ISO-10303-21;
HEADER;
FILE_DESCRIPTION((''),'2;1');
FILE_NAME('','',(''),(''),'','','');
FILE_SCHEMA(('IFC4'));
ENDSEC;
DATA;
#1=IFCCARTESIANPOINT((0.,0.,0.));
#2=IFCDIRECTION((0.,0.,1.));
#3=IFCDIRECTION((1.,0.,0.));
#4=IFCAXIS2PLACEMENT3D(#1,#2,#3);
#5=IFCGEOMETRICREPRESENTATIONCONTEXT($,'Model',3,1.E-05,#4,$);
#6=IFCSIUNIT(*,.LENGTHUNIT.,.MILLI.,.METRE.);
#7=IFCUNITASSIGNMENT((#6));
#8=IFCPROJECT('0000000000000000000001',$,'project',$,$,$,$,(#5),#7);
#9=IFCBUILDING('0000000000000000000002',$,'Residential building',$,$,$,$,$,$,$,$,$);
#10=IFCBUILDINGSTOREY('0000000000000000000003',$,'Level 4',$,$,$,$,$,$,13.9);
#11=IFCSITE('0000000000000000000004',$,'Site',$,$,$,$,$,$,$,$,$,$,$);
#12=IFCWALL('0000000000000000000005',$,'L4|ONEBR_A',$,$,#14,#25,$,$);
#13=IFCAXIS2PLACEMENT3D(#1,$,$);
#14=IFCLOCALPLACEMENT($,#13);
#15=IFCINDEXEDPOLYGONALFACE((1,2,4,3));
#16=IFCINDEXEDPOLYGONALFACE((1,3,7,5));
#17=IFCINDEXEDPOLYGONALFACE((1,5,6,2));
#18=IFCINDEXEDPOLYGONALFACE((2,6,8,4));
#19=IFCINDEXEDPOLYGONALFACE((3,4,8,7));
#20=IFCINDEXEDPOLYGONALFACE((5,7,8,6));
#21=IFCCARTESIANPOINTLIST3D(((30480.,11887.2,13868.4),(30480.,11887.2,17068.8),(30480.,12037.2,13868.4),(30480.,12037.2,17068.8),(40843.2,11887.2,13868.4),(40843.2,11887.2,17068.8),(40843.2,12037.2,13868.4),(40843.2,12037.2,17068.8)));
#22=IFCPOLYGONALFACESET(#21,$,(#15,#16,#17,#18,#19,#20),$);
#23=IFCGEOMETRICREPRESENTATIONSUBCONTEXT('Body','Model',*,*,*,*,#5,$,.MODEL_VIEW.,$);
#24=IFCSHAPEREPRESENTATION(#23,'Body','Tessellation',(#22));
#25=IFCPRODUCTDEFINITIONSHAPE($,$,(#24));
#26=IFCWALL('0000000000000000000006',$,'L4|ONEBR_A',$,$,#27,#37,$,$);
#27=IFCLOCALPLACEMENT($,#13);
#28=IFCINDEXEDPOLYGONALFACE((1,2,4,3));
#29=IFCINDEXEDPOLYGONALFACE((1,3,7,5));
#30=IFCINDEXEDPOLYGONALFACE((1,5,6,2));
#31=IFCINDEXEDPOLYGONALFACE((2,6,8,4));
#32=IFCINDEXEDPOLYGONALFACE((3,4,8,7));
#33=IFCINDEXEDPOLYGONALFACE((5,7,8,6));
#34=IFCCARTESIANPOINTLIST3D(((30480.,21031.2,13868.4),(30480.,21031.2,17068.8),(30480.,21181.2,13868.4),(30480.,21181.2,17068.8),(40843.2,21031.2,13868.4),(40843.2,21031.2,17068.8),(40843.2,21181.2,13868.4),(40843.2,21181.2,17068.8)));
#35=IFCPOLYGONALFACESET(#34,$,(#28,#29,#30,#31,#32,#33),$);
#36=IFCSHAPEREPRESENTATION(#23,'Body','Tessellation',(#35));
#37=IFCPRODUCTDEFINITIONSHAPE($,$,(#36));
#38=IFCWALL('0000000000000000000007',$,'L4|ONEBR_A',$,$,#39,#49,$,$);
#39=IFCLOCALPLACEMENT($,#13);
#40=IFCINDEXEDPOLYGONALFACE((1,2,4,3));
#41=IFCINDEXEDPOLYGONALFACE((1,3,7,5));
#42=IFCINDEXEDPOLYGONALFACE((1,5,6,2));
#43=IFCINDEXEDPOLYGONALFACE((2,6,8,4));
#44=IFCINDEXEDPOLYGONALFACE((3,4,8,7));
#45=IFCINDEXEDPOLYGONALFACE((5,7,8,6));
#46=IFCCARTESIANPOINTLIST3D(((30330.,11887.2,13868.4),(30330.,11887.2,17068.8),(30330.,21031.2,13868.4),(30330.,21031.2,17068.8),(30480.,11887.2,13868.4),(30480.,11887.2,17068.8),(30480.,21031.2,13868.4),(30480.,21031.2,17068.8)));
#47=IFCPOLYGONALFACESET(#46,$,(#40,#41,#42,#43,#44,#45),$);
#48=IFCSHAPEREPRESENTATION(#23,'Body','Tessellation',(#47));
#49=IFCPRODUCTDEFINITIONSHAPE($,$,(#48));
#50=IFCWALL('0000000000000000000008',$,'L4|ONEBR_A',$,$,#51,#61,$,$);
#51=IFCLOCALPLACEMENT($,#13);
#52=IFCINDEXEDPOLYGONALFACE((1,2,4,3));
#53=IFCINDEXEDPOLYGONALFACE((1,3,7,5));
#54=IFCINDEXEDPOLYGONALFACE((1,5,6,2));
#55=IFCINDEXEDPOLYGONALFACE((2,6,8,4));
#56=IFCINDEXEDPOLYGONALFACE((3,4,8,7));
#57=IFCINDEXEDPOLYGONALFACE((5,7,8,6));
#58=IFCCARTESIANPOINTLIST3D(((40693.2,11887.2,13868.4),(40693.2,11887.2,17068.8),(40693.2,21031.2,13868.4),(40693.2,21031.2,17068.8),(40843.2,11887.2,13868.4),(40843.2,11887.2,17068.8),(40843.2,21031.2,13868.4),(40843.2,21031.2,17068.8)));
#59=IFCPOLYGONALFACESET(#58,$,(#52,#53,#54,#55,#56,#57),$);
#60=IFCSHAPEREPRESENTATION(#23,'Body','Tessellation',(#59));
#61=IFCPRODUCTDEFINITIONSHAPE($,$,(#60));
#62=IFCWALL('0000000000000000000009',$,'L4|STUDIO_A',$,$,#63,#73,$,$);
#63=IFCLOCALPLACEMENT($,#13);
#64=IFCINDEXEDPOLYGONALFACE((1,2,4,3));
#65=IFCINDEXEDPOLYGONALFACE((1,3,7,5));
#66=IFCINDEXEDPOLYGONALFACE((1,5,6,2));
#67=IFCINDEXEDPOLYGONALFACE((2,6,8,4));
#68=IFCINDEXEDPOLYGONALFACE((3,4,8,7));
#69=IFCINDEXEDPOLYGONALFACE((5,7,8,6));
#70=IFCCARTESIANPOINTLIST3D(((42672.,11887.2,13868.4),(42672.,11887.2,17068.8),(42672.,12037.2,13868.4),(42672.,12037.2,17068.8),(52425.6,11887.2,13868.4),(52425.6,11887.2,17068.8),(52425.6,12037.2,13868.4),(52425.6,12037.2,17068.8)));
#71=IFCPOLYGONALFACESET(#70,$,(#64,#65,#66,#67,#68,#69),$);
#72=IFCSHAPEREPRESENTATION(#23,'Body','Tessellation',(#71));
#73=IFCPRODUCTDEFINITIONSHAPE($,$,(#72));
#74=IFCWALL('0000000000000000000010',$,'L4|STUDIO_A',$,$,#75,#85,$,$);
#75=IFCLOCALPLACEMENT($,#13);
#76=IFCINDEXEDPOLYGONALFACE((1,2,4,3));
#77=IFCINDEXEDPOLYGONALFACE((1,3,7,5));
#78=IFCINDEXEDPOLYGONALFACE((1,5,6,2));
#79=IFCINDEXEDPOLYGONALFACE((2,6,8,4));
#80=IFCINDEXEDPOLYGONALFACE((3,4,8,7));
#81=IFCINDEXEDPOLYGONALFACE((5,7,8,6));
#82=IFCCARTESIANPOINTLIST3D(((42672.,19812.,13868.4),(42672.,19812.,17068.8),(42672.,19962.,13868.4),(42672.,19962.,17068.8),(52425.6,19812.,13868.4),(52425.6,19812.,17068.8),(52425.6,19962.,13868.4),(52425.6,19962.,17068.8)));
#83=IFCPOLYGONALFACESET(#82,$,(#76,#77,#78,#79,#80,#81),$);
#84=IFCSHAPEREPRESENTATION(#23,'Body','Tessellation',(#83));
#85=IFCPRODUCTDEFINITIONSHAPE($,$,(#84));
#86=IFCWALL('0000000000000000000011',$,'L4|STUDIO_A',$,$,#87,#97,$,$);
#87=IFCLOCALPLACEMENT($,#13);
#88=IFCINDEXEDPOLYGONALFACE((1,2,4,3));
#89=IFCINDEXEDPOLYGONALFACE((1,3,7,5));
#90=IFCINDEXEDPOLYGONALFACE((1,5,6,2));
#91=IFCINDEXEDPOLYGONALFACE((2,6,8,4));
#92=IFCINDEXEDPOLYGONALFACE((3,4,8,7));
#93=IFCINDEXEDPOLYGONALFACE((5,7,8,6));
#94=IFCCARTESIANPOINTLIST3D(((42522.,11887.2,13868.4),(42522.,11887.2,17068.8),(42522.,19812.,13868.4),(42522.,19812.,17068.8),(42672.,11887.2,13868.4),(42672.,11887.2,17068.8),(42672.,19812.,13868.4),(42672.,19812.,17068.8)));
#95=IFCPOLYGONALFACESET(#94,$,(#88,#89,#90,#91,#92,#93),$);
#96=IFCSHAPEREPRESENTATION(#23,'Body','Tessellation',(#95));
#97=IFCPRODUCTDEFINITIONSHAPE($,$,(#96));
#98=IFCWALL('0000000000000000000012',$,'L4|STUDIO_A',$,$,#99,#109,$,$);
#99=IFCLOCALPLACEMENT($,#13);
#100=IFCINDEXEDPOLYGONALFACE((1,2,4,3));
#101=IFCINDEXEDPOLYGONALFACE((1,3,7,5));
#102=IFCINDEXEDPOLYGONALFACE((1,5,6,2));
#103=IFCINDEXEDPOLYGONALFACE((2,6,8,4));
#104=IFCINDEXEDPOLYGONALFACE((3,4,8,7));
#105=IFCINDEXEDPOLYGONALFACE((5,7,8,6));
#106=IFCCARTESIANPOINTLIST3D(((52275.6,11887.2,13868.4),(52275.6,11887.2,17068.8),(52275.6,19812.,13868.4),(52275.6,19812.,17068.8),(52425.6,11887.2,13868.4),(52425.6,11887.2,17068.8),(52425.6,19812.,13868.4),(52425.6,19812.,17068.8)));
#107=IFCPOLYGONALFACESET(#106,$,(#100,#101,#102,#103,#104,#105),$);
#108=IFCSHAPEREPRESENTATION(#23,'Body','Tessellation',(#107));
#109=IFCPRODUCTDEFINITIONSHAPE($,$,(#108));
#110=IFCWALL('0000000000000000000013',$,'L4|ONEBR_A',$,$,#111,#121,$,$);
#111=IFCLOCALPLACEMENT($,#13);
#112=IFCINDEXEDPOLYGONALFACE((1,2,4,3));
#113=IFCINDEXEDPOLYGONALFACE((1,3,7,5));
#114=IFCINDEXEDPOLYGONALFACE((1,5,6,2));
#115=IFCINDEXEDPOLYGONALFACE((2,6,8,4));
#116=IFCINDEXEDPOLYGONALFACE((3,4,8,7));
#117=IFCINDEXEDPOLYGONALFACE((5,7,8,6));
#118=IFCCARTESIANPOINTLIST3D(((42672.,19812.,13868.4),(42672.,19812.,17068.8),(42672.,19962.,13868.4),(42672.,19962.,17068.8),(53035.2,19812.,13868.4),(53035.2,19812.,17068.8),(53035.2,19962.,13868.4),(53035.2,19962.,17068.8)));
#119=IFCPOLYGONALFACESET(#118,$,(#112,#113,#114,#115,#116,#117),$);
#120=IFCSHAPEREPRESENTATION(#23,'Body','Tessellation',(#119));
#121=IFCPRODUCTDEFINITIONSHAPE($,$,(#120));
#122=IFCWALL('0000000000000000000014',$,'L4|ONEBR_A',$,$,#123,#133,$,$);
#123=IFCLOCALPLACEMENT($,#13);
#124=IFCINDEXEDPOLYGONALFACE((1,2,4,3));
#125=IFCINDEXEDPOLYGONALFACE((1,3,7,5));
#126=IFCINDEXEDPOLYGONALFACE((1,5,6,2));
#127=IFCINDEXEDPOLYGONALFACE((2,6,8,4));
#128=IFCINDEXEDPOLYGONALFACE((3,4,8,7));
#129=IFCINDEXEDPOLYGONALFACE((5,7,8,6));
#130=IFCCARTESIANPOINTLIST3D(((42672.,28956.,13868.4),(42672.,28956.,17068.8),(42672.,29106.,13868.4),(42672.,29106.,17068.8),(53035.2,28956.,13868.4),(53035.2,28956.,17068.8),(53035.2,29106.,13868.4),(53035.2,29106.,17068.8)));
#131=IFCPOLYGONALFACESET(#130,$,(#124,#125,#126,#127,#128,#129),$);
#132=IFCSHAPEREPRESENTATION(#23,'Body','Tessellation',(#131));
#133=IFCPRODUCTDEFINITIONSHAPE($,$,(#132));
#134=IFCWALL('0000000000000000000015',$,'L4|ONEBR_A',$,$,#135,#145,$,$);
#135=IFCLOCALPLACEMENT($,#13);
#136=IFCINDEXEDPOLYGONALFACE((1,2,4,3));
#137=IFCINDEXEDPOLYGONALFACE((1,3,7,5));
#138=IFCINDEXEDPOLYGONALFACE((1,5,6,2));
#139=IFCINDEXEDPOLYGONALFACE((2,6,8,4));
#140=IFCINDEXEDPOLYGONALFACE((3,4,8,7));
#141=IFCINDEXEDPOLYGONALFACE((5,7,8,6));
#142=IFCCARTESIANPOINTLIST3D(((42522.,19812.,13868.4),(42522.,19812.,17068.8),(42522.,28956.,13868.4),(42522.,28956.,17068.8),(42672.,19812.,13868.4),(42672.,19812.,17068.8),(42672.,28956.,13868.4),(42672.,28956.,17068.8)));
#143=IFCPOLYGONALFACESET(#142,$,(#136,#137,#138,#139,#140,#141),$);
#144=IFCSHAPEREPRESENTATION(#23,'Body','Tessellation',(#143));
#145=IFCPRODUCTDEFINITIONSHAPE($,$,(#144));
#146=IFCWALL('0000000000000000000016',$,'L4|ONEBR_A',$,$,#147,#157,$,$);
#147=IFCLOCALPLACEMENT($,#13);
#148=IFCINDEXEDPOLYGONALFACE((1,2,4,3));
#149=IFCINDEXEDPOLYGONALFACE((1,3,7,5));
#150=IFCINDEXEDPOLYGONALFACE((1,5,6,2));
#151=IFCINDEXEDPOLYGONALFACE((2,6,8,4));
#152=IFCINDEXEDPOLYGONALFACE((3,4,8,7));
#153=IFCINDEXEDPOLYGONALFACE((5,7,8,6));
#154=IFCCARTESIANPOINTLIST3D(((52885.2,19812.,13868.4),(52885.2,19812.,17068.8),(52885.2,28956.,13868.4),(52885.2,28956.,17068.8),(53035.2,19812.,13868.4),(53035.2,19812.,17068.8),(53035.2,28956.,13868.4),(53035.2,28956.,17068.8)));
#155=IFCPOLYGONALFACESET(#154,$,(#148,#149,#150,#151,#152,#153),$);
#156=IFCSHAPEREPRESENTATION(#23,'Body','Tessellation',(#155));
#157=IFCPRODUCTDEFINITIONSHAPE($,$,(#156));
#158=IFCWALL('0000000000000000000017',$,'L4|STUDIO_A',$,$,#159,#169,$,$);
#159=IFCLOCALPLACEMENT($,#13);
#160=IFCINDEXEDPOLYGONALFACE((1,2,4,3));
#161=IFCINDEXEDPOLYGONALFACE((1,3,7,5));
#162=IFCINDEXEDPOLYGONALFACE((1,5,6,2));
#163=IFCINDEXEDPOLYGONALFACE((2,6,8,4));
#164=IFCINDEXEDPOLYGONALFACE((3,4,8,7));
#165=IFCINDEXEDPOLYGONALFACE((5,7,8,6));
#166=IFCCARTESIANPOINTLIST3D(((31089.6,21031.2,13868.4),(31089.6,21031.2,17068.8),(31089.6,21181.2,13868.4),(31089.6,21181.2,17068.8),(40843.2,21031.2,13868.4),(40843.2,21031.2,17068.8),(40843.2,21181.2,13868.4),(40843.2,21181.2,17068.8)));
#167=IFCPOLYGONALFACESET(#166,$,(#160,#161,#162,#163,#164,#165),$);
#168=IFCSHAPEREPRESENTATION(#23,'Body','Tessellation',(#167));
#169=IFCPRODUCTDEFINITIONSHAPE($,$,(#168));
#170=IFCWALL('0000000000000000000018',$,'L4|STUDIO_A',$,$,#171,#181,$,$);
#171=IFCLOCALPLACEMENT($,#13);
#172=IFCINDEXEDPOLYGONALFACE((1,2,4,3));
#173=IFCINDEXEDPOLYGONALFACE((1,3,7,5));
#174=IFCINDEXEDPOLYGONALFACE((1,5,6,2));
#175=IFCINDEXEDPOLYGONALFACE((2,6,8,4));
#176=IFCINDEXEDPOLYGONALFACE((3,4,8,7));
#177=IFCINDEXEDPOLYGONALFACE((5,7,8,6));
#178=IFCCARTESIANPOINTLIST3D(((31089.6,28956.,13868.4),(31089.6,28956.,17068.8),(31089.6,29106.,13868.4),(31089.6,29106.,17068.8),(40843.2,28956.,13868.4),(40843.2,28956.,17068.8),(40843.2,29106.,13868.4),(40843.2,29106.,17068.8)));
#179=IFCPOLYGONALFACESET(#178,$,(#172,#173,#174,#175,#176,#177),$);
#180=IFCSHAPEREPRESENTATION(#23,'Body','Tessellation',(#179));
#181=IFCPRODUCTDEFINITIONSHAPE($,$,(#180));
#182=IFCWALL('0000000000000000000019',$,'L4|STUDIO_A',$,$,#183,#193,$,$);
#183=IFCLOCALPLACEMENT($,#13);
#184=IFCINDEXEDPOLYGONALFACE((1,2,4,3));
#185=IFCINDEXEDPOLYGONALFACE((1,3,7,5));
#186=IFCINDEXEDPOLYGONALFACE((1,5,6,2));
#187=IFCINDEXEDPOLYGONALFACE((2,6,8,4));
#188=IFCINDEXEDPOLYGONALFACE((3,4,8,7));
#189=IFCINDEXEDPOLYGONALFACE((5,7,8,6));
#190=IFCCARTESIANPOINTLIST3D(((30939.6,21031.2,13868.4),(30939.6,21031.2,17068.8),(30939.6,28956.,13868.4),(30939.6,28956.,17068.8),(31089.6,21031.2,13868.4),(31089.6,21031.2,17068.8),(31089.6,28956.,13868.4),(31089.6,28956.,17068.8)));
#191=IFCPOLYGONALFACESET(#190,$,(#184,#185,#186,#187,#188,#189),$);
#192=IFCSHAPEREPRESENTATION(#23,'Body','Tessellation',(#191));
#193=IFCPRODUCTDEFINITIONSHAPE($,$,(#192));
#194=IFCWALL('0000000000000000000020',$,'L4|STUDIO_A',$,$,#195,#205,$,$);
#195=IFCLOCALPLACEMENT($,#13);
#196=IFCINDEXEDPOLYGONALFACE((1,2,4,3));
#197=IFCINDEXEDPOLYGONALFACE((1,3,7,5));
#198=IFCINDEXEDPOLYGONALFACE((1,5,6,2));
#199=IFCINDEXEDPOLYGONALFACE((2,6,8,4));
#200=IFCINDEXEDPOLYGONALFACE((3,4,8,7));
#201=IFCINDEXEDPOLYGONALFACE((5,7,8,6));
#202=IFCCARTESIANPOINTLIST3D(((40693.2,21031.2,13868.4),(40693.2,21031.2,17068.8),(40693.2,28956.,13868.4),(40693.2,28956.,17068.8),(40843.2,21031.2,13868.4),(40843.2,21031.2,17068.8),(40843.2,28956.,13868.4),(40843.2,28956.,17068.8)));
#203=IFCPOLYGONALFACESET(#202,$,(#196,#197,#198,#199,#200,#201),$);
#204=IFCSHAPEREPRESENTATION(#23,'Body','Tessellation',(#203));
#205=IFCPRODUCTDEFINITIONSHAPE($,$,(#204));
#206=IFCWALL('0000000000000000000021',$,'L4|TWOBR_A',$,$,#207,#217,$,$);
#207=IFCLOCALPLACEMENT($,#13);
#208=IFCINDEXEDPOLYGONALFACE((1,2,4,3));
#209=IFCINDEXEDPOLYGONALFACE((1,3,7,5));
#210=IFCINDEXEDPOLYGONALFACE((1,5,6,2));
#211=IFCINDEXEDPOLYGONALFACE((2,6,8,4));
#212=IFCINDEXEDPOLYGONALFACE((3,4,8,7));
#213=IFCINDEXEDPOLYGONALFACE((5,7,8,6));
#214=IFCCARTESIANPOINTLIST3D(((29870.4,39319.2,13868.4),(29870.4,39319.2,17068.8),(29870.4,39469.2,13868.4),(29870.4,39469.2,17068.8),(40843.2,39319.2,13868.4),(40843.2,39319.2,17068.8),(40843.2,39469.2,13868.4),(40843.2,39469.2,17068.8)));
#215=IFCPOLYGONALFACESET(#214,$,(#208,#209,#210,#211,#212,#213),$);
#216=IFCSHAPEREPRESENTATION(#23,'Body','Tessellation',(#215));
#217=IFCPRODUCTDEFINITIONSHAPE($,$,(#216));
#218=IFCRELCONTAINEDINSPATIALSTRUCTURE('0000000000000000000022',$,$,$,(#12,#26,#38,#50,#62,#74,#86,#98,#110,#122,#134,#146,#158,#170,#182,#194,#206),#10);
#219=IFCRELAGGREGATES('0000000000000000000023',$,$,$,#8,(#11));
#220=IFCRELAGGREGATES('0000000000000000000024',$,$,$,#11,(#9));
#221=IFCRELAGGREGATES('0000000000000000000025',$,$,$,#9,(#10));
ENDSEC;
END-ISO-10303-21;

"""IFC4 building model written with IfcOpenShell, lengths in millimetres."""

from ifc_helpers import new_model, si_unit, frame, origin_with_axes, place, context, subcontext, project, spatial, indexed_curve, outline, extrude, element, save


model = new_model("IFC4")

# Units and contexts
model_context = context("Model", 3, precision=1e-05, world=origin_with_axes())
body_context = subcontext(model_context, "Body", "Model", "MODEL_VIEW")
ifc_project = project(units=[si_unit("LENGTHUNIT", "METRE", prefix="MILLI")], contexts=[model_context])

# Site, building, storey
site = spatial("IfcSite", under=ifc_project, Name="Site")
building = spatial("IfcBuilding", under=site, Name="Residential building")
storey = spatial("IfcBuildingStorey", under=building, Name="Level 4", Elevation=13.9)

# Walls
for number, where, z_axis, x_axis, name in (
    (1, (30480.0, 11887.2, 13868.4), (0.0, 0.0, 1.0), (1.0, 0.0, 0.0), "L4|ONEBR_A"),
    (2, (30480.0, 21031.2, 13868.4), (0.0, 0.0, 1.0), (1.0, 0.0, 0.0), "L4|ONEBR_A"),
):
    element("IfcWall", number, at=place(None, frame(where, z_axis=z_axis, x_axis=x_axis)), inside=storey, Name=name, context=body_context, shape_type="SweptSolid", body=[
        extrude(outline(indexed_curve([(0.0, 0.0), (0.0, 150.0), (10363.2, 150.0), (10363.2, 0.0), (0.0, 0.0)], self_intersect=False)), origin_with_axes(), (0.0, 0.0, 1.0), 3200.4),
    ])
for number, where, z_axis, x_axis, name in (
    (3, (30480.0, 11887.2, 13868.4), (0.0, 0.0, 1.0), (0.0, 1.0, 0.0), "L4|ONEBR_A"),
    (4, (40843.2, 11887.2, 13868.4), (0.0, 0.0, 1.0), (0.0, 1.0, 0.0), "L4|ONEBR_A"),
):
    element("IfcWall", number, at=place(None, frame(where, z_axis=z_axis, x_axis=x_axis)), inside=storey, Name=name, context=body_context, shape_type="SweptSolid", body=[
        extrude(outline(indexed_curve([(0.0, 0.0), (0.0, 150.0), (9144.0, 150.0), (9144.0, 0.0), (0.0, 0.0)], self_intersect=False)), origin_with_axes(), (0.0, 0.0, 1.0), 3200.4),
    ])
for number, where, z_axis, x_axis, name in (
    (5, (42672.0, 11887.2, 13868.4), (0.0, 0.0, 1.0), (1.0, 0.0, 0.0), "L4|STUDIO_A"),
    (6, (42672.0, 19812.0, 13868.4), (0.0, 0.0, 1.0), (1.0, 0.0, 0.0), "L4|STUDIO_A"),
):
    element("IfcWall", number, at=place(None, frame(where, z_axis=z_axis, x_axis=x_axis)), inside=storey, Name=name, context=body_context, shape_type="SweptSolid", body=[
        extrude(outline(indexed_curve([(0.0, 0.0), (0.0, 150.0), (9753.6, 150.0), (9753.6, 0.0), (0.0, 0.0)], self_intersect=False)), origin_with_axes(), (0.0, 0.0, 1.0), 3200.4),
    ])
for number, where, z_axis, x_axis, name in (
    (7, (42672.0, 11887.2, 13868.4), (0.0, 0.0, 1.0), (0.0, 1.0, 0.0), "L4|STUDIO_A"),
    (8, (52425.6, 11887.2, 13868.4), (0.0, 0.0, 1.0), (0.0, 1.0, 0.0), "L4|STUDIO_A"),
):
    element("IfcWall", number, at=place(None, frame(where, z_axis=z_axis, x_axis=x_axis)), inside=storey, Name=name, context=body_context, shape_type="SweptSolid", body=[
        extrude(outline(indexed_curve([(0.0, 0.0), (0.0, 150.0), (7924.8, 150.0), (7924.8, 0.0), (0.0, 0.0)], self_intersect=False)), origin_with_axes(), (0.0, 0.0, 1.0), 3200.4),
    ])
for number, where, z_axis, x_axis, name in (
    (9, (42672.0, 19812.0, 13868.4), (0.0, 0.0, 1.0), (1.0, 0.0, 0.0), "L4|ONEBR_A"),
    (10, (42672.0, 28956.0, 13868.4), (0.0, 0.0, 1.0), (1.0, 0.0, 0.0), "L4|ONEBR_A"),
):
    element("IfcWall", number, at=place(None, frame(where, z_axis=z_axis, x_axis=x_axis)), inside=storey, Name=name, context=body_context, shape_type="SweptSolid", body=[
        extrude(outline(indexed_curve([(0.0, 0.0), (0.0, 150.0), (10363.2, 150.0), (10363.2, 0.0), (0.0, 0.0)], self_intersect=False)), origin_with_axes(), (0.0, 0.0, 1.0), 3200.4),
    ])
for number, where, z_axis, x_axis, name in (
    (11, (42672.0, 19812.0, 13868.4), (0.0, 0.0, 1.0), (0.0, 1.0, 0.0), "L4|ONEBR_A"),
    (12, (53035.2, 19812.0, 13868.4), (0.0, 0.0, 1.0), (0.0, 1.0, 0.0), "L4|ONEBR_A"),
):
    element("IfcWall", number, at=place(None, frame(where, z_axis=z_axis, x_axis=x_axis)), inside=storey, Name=name, context=body_context, shape_type="SweptSolid", body=[
        extrude(outline(indexed_curve([(0.0, 0.0), (0.0, 150.0), (9144.0, 150.0), (9144.0, 0.0), (0.0, 0.0)], self_intersect=False)), origin_with_axes(), (0.0, 0.0, 1.0), 3200.4),
    ])
for number, where, z_axis, x_axis, name in (
    (13, (31089.6, 21031.2, 13868.4), (0.0, 0.0, 1.0), (1.0, 0.0, 0.0), "L4|STUDIO_A"),
    (14, (31089.6, 28956.0, 13868.4), (0.0, 0.0, 1.0), (1.0, 0.0, 0.0), "L4|STUDIO_A"),
):
    element("IfcWall", number, at=place(None, frame(where, z_axis=z_axis, x_axis=x_axis)), inside=storey, Name=name, context=body_context, shape_type="SweptSolid", body=[
        extrude(outline(indexed_curve([(0.0, 0.0), (0.0, 150.0), (9753.6, 150.0), (9753.6, 0.0), (0.0, 0.0)], self_intersect=False)), origin_with_axes(), (0.0, 0.0, 1.0), 3200.4),
    ])
for number, where, z_axis, x_axis, name in (
    (15, (31089.6, 21031.2, 13868.4), (0.0, 0.0, 1.0), (0.0, 1.0, 0.0), "L4|STUDIO_A"),
    (16, (40843.2, 21031.2, 13868.4), (0.0, 0.0, 1.0), (0.0, 1.0, 0.0), "L4|STUDIO_A"),
):
    element("IfcWall", number, at=place(None, frame(where, z_axis=z_axis, x_axis=x_axis)), inside=storey, Name=name, context=body_context, shape_type="SweptSolid", body=[
        extrude(outline(indexed_curve([(0.0, 0.0), (0.0, 150.0), (7924.8, 150.0), (7924.8, 0.0), (0.0, 0.0)], self_intersect=False)), origin_with_axes(), (0.0, 0.0, 1.0), 3200.4),
    ])
wall_placement = place(None, frame((29870.4, 39319.2, 13868.4), z_axis=(0.0, 0.0, 1.0), x_axis=(1.0, 0.0, 0.0)))
element("IfcWall", 17, at=wall_placement, inside=storey, Name="L4|TWOBR_A", context=body_context, shape_type="SweptSolid", body=[
    extrude(outline(indexed_curve([(0.0, 0.0), (0.0, 150.0), (10972.8, 150.0), (10972.8, 0.0), (0.0, 0.0)], self_intersect=False)), origin_with_axes(), (0.0, 0.0, 1.0), 3200.4),
])

save(model, "model.ifc")
